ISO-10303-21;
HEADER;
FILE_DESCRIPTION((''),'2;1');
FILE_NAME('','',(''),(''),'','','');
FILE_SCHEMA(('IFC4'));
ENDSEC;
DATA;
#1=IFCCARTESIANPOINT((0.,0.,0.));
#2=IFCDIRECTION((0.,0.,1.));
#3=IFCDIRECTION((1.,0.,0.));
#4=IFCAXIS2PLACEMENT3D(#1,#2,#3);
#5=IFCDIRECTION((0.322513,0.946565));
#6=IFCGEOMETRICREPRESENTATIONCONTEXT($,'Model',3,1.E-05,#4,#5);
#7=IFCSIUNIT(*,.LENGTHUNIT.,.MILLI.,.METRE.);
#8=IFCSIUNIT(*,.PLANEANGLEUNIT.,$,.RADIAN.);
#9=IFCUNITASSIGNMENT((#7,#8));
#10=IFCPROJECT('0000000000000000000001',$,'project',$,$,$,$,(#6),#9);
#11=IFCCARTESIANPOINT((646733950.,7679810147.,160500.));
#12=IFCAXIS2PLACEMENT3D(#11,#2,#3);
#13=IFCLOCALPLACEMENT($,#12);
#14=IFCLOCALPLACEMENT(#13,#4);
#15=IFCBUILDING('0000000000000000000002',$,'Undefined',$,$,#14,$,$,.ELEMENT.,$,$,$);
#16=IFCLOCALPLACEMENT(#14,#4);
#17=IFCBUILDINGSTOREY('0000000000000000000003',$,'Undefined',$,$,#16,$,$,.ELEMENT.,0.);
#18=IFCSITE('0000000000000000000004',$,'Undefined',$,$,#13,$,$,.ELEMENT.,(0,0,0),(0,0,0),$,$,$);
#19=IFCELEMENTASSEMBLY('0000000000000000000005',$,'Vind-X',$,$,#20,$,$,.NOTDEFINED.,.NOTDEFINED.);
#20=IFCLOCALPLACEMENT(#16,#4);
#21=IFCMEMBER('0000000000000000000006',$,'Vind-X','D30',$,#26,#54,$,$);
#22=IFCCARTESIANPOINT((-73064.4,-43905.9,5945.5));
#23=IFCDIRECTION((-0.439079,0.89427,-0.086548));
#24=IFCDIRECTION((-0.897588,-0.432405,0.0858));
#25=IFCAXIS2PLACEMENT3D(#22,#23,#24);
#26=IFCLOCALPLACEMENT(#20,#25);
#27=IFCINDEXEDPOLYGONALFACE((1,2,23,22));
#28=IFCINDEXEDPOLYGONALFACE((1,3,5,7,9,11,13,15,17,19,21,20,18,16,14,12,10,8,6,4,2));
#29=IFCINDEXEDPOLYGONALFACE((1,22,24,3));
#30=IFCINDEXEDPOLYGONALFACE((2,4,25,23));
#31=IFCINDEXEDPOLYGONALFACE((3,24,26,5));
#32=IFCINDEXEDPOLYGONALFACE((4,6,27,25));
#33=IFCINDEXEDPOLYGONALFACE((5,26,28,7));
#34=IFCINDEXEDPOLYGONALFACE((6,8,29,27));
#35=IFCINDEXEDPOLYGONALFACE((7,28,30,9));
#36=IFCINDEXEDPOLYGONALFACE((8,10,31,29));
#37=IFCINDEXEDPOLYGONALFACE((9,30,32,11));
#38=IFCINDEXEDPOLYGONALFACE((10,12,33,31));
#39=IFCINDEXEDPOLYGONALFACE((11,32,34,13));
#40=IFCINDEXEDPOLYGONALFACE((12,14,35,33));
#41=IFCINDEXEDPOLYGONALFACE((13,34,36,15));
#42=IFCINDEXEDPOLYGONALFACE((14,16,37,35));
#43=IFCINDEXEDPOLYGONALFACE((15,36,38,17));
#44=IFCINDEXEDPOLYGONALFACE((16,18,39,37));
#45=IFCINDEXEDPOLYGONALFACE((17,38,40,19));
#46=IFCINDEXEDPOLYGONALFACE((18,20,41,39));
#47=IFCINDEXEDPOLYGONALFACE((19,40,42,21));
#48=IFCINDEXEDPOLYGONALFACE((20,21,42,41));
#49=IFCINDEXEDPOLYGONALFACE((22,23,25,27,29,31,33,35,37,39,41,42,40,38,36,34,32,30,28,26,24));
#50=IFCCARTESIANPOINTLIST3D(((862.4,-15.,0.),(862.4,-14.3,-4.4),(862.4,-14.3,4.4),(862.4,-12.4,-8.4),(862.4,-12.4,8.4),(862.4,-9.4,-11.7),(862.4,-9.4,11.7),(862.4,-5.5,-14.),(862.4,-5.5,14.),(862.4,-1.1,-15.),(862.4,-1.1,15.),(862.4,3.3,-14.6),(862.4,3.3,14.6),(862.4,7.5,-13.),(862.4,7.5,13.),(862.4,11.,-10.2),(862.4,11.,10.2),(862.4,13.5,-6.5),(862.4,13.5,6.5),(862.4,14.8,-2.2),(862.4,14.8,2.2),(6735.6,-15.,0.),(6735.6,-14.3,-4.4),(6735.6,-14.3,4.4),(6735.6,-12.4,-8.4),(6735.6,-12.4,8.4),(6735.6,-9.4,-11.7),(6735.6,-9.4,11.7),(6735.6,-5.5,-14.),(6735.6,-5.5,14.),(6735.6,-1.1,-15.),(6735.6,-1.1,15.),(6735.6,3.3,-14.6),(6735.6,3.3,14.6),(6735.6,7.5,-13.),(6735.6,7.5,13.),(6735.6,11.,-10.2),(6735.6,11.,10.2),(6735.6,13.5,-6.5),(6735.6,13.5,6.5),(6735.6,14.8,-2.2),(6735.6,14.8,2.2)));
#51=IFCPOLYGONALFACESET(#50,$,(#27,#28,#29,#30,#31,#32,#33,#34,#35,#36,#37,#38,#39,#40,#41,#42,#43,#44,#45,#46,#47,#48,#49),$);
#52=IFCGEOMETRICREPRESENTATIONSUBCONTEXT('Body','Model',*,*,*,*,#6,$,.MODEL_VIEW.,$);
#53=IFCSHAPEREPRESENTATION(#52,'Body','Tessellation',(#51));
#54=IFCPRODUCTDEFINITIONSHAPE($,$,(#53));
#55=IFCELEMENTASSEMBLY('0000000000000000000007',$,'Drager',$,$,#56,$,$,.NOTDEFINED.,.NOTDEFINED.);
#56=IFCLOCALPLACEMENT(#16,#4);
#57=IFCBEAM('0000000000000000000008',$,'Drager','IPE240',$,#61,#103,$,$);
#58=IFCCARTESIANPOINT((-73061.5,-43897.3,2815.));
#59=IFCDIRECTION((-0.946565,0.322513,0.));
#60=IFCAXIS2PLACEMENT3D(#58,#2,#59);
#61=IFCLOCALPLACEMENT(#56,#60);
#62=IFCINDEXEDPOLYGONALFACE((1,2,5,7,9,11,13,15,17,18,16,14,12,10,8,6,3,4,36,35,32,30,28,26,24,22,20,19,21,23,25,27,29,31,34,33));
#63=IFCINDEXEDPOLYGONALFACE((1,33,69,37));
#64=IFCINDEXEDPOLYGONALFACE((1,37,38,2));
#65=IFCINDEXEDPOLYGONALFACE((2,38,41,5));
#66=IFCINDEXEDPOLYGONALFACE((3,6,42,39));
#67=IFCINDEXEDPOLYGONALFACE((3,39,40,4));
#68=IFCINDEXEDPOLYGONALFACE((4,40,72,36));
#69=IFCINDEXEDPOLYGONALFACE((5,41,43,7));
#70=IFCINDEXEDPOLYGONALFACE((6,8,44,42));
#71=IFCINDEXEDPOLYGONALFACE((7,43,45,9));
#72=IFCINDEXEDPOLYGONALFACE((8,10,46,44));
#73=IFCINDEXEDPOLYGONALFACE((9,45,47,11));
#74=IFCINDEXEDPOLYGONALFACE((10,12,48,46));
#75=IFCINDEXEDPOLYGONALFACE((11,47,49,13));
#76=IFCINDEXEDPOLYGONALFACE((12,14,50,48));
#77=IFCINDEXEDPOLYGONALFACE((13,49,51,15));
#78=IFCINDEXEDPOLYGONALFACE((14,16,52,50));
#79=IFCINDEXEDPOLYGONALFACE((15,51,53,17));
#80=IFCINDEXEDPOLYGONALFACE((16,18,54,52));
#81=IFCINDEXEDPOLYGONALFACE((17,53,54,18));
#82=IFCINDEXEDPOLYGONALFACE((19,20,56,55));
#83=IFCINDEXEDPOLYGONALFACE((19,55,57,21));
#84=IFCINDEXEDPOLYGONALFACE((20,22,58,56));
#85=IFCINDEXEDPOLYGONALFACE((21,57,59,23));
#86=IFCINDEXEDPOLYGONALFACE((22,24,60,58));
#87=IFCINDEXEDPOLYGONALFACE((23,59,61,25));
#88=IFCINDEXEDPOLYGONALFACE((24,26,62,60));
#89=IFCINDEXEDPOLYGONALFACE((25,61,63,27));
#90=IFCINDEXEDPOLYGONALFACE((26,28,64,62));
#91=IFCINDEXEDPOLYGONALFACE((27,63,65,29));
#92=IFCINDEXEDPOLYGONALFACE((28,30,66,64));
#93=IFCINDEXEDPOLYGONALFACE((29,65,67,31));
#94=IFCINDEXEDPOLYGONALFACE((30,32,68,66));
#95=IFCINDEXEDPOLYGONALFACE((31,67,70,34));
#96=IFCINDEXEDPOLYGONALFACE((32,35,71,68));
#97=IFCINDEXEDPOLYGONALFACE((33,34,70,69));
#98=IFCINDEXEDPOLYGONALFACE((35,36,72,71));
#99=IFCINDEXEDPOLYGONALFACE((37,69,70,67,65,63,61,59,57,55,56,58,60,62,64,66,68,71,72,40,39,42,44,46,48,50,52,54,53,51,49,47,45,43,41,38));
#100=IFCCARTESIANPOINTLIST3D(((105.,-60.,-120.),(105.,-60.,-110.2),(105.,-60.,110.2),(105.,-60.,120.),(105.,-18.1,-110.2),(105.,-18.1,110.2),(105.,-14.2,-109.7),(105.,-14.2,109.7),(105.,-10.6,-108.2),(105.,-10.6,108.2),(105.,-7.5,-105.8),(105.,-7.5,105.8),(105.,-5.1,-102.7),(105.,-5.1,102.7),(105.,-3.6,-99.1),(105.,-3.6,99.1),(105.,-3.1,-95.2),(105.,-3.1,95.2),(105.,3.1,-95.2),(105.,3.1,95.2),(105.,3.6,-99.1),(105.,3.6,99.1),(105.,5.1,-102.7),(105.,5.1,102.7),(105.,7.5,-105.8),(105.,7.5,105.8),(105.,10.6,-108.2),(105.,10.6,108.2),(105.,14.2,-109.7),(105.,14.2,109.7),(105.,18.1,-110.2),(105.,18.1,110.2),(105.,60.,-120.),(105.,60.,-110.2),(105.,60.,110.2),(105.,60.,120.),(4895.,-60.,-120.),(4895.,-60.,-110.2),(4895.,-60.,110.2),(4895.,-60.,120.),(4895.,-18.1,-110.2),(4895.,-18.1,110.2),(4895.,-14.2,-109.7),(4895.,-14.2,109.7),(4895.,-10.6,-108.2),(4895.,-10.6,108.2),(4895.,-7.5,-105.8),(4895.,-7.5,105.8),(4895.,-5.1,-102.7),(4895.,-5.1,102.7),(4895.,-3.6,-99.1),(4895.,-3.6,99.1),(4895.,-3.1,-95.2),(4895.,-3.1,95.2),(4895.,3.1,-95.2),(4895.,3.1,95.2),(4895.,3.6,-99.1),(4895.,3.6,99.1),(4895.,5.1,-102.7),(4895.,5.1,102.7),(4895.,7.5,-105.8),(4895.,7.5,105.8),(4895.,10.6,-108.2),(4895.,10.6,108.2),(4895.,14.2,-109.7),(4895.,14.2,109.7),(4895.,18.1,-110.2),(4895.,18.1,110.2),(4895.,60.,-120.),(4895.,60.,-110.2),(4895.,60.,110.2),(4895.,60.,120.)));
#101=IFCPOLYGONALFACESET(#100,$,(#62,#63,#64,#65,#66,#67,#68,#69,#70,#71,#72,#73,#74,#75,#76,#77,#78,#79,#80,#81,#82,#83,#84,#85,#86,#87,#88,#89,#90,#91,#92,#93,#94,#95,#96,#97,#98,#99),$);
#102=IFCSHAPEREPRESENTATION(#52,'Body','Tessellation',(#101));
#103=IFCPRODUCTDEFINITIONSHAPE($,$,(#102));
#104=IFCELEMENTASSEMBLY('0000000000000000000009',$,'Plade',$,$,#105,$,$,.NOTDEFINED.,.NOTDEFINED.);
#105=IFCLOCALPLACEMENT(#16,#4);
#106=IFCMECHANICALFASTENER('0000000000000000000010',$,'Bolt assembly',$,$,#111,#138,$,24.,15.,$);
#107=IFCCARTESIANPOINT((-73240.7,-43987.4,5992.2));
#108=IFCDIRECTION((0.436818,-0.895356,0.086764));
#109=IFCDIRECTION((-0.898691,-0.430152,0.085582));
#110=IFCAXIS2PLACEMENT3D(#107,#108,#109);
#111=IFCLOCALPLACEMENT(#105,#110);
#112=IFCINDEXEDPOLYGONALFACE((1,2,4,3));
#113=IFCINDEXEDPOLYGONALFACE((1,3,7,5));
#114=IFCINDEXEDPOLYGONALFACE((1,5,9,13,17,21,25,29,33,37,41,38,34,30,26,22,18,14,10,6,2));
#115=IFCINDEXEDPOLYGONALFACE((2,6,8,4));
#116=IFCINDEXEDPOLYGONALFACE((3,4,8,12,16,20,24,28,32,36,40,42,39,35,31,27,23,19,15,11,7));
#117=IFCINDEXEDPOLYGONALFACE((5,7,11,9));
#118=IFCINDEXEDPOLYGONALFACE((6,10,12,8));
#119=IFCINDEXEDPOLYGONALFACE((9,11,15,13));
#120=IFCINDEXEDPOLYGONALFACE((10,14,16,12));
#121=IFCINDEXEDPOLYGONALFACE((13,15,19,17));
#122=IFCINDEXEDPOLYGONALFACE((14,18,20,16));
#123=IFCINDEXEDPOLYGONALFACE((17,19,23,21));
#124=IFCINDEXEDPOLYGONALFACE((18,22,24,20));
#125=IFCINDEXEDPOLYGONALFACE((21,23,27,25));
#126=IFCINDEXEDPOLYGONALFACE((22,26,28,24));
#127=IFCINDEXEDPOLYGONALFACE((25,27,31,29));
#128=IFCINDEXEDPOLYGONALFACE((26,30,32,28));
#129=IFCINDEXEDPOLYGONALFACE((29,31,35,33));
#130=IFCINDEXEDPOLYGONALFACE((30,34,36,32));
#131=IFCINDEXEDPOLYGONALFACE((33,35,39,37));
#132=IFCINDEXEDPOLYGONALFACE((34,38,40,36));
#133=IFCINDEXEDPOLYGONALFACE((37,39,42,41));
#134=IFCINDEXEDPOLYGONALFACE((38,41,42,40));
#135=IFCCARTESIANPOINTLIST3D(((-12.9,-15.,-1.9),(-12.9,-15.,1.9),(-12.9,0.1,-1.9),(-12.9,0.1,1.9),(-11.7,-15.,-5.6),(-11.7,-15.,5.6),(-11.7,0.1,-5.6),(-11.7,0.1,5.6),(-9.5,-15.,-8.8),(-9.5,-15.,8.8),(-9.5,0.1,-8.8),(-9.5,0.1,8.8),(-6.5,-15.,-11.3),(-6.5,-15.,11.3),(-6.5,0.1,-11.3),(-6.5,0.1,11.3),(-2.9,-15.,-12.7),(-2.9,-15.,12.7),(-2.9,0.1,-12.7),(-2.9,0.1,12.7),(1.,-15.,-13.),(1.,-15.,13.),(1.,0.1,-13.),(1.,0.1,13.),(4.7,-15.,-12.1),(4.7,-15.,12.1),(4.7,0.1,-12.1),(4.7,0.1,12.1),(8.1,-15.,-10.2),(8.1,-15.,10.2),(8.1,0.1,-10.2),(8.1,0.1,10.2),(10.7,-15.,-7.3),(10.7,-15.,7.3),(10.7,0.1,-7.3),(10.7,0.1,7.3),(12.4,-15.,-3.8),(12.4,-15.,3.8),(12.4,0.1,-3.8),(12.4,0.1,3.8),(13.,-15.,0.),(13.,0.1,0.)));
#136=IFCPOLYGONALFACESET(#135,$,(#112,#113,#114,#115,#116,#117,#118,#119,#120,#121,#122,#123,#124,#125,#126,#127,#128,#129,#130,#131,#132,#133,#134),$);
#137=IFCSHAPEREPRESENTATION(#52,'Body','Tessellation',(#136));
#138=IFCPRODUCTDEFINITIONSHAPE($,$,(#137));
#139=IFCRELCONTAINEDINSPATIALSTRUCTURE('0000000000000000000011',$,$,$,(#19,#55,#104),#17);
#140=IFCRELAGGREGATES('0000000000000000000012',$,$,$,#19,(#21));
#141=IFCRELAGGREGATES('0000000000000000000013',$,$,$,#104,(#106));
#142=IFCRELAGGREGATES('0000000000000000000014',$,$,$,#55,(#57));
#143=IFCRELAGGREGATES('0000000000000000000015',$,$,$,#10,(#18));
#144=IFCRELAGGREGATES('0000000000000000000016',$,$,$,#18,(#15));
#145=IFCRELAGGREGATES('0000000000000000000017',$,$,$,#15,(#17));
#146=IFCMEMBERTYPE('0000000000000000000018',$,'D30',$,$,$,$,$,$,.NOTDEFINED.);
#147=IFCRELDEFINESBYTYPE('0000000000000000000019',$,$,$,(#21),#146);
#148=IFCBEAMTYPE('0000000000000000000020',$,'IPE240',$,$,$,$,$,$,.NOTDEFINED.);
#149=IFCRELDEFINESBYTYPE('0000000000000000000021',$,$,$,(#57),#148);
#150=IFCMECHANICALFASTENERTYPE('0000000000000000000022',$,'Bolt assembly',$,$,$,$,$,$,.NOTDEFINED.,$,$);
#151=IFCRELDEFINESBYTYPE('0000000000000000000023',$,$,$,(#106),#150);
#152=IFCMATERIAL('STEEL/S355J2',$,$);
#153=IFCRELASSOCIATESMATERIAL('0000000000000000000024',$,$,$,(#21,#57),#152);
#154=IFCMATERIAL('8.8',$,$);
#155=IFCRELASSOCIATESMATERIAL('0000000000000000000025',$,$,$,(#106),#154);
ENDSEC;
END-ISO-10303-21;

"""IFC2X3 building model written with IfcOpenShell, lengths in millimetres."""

from ifc_helpers import new_model, si_unit, direction, frame, origin_with_axes, origin_2d_with_axis, place, context, subcontext, project, spatial, circle, i_section, extrude, clip, halfspace, source, transform, mapped, material, type_object, element, aggregate, save


model = new_model("IFC2X3")

# Units and contexts
model_context = context("Model", 3, precision=1e-05, world=origin_with_axes(), true_north=direction((0.322513, 0.946565)))
body_context = subcontext(model_context, "Body", "Model", "MODEL_VIEW")
ifc_project = project(units=[si_unit("LENGTHUNIT", "METRE", prefix="MILLI"), si_unit("PLANEANGLEUNIT", "RADIAN")], contexts=[model_context])

# Site, building, storey
site_placement = place(None, frame((646733950.0, 7679810147.0, 160500.0), z_axis=(0.0, 0.0, 1.0), x_axis=(1.0, 0.0, 0.0)))
site = spatial("IfcSite", under=ifc_project, at=site_placement, Name="Undefined", CompositionType="ELEMENT", RefLatitude=(0, 0, 0), RefLongitude=(0, 0, 0))
building_placement = place(site_placement, origin_with_axes())
building = spatial("IfcBuilding", under=site, at=building_placement, Name="Undefined", CompositionType="ELEMENT")
storey_placement = place(building_placement, origin_with_axes())
storey = spatial("IfcBuildingStorey", under=building, at=storey_placement, Name="Undefined", CompositionType="ELEMENT", Elevation=0.0)

# Element assembly, member
assembly_1_placement = place(storey_placement, origin_with_axes())
assembly_1 = element("IfcElementAssembly", 1, at=assembly_1_placement, inside=storey, Name="Vind-X", AssemblyPlace="NOTDEFINED", PredefinedType="NOTDEFINED")
ifc_material_1 = material(Name="STEEL/S355J2")
member_type = type_object("IfcMemberType", Name="D30", PredefinedType="NOTDEFINED")
member_placement = place(assembly_1_placement, frame((-73064.4, -43905.9, 5945.5), z_axis=(-0.439079, 0.89427, -0.086548), x_axis=(-0.897588, -0.432405, 0.0858)))
member = element("IfcMember", 2, at=member_placement, type_object=member_type, material=ifc_material_1, Name="Vind-X", Description="D30", context=body_context, shape_type="Clipping", body=[
    clip(clip(extrude(circle(Radius=15.0, at=origin_2d_with_axis()), frame((6820.6, 0.0, 0.0), z_axis=(-1.0, 0.0, 0.0), x_axis=(0.0, -1.0, 0.0)), (0.0, 0.0, 1.0), 6820.6), halfspace(frame((6735.6, 6.0, 16.0), z_axis=(-1.0, 0.0, 0.0), x_axis=(0.0, -1.0, 0.0)), True)), halfspace(frame((862.4, 6.0, 10.2), z_axis=(-1.0, 0.0, 0.0), x_axis=(0.0, -1.0, 0.0)), False)),
])

# Element assembly, beam
assembly_2_placement = place(storey_placement, origin_with_axes())
assembly_2 = element("IfcElementAssembly", 3, at=assembly_2_placement, inside=storey, Name="Drager", AssemblyPlace="NOTDEFINED", PredefinedType="NOTDEFINED")
beam_type_1 = type_object("IfcBeamType", Name="IPE240", PredefinedType="NOTDEFINED")
beam_1_placement = place(assembly_2_placement, frame((-73061.5, -43897.3, 2815.0), z_axis=(0.0, 0.0, 1.0), x_axis=(-0.946565, 0.322513, 0.0)))
beam_1 = element("IfcBeam", 4, at=beam_1_placement, type_object=beam_type_1, material=ifc_material_1, Name="Drager", Description="IPE240", context=body_context, shape_type="Clipping", body=[
    clip(clip(extrude(i_section(OverallWidth=120.0, OverallDepth=240.0, WebThickness=6.2, FlangeThickness=9.8, FilletRadius=15.0, at=origin_2d_with_axis()), frame((5000.0, 0.0, 0.0), z_axis=(-1.0, 0.0, 0.0), x_axis=(0.0, -1.0, 0.0)), (0.0, 0.0, 1.0), 5000.0), halfspace(frame((4895.0, 9.1, 120.0), z_axis=(-1.0, 0.0, 0.0), x_axis=(0.0, -1.0, 0.0)), True)), halfspace(frame((105.0, 9.1, 120.0), z_axis=(1.0, 0.0, 0.0), x_axis=(0.0, 1.0, 0.0)), True)),
])

# Element assembly
assembly_3_placement = place(storey_placement, origin_with_axes())
assembly_3 = element("IfcElementAssembly", 5, at=assembly_3_placement, inside=storey, Name="Plade", AssemblyPlace="NOTDEFINED", PredefinedType="NOTDEFINED")

# Shared definitions
ifc_material_2 = material(Name="8.8")
mechanical_fastener_type = type_object("IfcMechanicalFastenerType", Name="Bolt assembly")
aggregate(assembly_1, [member])

# Mechanical fastener
shared_shape_1 = source(origin_with_axes(), body_context, "Body", "SweptSolid", [
    extrude(circle(Radius=13.0, at=origin_2d_with_axis()), frame((0.0, -15.0, 0.0), z_axis=(0.0, 1.0, 0.0), x_axis=(1.0, 0.0, 0.0)), (0.0, 0.0, 1.0), 15.1),
])
mechanical_fastener_1_placement = place(assembly_3_placement, frame((-73240.7, -43987.4, 5992.2), z_axis=(0.436818, -0.895356, 0.086764), x_axis=(-0.898691, -0.430152, 0.085582)))
mechanical_fastener_1 = element("IfcMechanicalFastener", 6, at=mechanical_fastener_1_placement, type_object=mechanical_fastener_type, material=ifc_material_2, Name="Bolt assembly", NominalDiameter=24.0, NominalLength=15.0, context=body_context, shape_type="MappedRepresentation", body=[
    mapped(shared_shape_1, transform((0.0, 0.0, 0.0))),
])
aggregate(assembly_3, [mechanical_fastener_1])
aggregate(assembly_2, [beam_1])

save(model, "model.ifc")
